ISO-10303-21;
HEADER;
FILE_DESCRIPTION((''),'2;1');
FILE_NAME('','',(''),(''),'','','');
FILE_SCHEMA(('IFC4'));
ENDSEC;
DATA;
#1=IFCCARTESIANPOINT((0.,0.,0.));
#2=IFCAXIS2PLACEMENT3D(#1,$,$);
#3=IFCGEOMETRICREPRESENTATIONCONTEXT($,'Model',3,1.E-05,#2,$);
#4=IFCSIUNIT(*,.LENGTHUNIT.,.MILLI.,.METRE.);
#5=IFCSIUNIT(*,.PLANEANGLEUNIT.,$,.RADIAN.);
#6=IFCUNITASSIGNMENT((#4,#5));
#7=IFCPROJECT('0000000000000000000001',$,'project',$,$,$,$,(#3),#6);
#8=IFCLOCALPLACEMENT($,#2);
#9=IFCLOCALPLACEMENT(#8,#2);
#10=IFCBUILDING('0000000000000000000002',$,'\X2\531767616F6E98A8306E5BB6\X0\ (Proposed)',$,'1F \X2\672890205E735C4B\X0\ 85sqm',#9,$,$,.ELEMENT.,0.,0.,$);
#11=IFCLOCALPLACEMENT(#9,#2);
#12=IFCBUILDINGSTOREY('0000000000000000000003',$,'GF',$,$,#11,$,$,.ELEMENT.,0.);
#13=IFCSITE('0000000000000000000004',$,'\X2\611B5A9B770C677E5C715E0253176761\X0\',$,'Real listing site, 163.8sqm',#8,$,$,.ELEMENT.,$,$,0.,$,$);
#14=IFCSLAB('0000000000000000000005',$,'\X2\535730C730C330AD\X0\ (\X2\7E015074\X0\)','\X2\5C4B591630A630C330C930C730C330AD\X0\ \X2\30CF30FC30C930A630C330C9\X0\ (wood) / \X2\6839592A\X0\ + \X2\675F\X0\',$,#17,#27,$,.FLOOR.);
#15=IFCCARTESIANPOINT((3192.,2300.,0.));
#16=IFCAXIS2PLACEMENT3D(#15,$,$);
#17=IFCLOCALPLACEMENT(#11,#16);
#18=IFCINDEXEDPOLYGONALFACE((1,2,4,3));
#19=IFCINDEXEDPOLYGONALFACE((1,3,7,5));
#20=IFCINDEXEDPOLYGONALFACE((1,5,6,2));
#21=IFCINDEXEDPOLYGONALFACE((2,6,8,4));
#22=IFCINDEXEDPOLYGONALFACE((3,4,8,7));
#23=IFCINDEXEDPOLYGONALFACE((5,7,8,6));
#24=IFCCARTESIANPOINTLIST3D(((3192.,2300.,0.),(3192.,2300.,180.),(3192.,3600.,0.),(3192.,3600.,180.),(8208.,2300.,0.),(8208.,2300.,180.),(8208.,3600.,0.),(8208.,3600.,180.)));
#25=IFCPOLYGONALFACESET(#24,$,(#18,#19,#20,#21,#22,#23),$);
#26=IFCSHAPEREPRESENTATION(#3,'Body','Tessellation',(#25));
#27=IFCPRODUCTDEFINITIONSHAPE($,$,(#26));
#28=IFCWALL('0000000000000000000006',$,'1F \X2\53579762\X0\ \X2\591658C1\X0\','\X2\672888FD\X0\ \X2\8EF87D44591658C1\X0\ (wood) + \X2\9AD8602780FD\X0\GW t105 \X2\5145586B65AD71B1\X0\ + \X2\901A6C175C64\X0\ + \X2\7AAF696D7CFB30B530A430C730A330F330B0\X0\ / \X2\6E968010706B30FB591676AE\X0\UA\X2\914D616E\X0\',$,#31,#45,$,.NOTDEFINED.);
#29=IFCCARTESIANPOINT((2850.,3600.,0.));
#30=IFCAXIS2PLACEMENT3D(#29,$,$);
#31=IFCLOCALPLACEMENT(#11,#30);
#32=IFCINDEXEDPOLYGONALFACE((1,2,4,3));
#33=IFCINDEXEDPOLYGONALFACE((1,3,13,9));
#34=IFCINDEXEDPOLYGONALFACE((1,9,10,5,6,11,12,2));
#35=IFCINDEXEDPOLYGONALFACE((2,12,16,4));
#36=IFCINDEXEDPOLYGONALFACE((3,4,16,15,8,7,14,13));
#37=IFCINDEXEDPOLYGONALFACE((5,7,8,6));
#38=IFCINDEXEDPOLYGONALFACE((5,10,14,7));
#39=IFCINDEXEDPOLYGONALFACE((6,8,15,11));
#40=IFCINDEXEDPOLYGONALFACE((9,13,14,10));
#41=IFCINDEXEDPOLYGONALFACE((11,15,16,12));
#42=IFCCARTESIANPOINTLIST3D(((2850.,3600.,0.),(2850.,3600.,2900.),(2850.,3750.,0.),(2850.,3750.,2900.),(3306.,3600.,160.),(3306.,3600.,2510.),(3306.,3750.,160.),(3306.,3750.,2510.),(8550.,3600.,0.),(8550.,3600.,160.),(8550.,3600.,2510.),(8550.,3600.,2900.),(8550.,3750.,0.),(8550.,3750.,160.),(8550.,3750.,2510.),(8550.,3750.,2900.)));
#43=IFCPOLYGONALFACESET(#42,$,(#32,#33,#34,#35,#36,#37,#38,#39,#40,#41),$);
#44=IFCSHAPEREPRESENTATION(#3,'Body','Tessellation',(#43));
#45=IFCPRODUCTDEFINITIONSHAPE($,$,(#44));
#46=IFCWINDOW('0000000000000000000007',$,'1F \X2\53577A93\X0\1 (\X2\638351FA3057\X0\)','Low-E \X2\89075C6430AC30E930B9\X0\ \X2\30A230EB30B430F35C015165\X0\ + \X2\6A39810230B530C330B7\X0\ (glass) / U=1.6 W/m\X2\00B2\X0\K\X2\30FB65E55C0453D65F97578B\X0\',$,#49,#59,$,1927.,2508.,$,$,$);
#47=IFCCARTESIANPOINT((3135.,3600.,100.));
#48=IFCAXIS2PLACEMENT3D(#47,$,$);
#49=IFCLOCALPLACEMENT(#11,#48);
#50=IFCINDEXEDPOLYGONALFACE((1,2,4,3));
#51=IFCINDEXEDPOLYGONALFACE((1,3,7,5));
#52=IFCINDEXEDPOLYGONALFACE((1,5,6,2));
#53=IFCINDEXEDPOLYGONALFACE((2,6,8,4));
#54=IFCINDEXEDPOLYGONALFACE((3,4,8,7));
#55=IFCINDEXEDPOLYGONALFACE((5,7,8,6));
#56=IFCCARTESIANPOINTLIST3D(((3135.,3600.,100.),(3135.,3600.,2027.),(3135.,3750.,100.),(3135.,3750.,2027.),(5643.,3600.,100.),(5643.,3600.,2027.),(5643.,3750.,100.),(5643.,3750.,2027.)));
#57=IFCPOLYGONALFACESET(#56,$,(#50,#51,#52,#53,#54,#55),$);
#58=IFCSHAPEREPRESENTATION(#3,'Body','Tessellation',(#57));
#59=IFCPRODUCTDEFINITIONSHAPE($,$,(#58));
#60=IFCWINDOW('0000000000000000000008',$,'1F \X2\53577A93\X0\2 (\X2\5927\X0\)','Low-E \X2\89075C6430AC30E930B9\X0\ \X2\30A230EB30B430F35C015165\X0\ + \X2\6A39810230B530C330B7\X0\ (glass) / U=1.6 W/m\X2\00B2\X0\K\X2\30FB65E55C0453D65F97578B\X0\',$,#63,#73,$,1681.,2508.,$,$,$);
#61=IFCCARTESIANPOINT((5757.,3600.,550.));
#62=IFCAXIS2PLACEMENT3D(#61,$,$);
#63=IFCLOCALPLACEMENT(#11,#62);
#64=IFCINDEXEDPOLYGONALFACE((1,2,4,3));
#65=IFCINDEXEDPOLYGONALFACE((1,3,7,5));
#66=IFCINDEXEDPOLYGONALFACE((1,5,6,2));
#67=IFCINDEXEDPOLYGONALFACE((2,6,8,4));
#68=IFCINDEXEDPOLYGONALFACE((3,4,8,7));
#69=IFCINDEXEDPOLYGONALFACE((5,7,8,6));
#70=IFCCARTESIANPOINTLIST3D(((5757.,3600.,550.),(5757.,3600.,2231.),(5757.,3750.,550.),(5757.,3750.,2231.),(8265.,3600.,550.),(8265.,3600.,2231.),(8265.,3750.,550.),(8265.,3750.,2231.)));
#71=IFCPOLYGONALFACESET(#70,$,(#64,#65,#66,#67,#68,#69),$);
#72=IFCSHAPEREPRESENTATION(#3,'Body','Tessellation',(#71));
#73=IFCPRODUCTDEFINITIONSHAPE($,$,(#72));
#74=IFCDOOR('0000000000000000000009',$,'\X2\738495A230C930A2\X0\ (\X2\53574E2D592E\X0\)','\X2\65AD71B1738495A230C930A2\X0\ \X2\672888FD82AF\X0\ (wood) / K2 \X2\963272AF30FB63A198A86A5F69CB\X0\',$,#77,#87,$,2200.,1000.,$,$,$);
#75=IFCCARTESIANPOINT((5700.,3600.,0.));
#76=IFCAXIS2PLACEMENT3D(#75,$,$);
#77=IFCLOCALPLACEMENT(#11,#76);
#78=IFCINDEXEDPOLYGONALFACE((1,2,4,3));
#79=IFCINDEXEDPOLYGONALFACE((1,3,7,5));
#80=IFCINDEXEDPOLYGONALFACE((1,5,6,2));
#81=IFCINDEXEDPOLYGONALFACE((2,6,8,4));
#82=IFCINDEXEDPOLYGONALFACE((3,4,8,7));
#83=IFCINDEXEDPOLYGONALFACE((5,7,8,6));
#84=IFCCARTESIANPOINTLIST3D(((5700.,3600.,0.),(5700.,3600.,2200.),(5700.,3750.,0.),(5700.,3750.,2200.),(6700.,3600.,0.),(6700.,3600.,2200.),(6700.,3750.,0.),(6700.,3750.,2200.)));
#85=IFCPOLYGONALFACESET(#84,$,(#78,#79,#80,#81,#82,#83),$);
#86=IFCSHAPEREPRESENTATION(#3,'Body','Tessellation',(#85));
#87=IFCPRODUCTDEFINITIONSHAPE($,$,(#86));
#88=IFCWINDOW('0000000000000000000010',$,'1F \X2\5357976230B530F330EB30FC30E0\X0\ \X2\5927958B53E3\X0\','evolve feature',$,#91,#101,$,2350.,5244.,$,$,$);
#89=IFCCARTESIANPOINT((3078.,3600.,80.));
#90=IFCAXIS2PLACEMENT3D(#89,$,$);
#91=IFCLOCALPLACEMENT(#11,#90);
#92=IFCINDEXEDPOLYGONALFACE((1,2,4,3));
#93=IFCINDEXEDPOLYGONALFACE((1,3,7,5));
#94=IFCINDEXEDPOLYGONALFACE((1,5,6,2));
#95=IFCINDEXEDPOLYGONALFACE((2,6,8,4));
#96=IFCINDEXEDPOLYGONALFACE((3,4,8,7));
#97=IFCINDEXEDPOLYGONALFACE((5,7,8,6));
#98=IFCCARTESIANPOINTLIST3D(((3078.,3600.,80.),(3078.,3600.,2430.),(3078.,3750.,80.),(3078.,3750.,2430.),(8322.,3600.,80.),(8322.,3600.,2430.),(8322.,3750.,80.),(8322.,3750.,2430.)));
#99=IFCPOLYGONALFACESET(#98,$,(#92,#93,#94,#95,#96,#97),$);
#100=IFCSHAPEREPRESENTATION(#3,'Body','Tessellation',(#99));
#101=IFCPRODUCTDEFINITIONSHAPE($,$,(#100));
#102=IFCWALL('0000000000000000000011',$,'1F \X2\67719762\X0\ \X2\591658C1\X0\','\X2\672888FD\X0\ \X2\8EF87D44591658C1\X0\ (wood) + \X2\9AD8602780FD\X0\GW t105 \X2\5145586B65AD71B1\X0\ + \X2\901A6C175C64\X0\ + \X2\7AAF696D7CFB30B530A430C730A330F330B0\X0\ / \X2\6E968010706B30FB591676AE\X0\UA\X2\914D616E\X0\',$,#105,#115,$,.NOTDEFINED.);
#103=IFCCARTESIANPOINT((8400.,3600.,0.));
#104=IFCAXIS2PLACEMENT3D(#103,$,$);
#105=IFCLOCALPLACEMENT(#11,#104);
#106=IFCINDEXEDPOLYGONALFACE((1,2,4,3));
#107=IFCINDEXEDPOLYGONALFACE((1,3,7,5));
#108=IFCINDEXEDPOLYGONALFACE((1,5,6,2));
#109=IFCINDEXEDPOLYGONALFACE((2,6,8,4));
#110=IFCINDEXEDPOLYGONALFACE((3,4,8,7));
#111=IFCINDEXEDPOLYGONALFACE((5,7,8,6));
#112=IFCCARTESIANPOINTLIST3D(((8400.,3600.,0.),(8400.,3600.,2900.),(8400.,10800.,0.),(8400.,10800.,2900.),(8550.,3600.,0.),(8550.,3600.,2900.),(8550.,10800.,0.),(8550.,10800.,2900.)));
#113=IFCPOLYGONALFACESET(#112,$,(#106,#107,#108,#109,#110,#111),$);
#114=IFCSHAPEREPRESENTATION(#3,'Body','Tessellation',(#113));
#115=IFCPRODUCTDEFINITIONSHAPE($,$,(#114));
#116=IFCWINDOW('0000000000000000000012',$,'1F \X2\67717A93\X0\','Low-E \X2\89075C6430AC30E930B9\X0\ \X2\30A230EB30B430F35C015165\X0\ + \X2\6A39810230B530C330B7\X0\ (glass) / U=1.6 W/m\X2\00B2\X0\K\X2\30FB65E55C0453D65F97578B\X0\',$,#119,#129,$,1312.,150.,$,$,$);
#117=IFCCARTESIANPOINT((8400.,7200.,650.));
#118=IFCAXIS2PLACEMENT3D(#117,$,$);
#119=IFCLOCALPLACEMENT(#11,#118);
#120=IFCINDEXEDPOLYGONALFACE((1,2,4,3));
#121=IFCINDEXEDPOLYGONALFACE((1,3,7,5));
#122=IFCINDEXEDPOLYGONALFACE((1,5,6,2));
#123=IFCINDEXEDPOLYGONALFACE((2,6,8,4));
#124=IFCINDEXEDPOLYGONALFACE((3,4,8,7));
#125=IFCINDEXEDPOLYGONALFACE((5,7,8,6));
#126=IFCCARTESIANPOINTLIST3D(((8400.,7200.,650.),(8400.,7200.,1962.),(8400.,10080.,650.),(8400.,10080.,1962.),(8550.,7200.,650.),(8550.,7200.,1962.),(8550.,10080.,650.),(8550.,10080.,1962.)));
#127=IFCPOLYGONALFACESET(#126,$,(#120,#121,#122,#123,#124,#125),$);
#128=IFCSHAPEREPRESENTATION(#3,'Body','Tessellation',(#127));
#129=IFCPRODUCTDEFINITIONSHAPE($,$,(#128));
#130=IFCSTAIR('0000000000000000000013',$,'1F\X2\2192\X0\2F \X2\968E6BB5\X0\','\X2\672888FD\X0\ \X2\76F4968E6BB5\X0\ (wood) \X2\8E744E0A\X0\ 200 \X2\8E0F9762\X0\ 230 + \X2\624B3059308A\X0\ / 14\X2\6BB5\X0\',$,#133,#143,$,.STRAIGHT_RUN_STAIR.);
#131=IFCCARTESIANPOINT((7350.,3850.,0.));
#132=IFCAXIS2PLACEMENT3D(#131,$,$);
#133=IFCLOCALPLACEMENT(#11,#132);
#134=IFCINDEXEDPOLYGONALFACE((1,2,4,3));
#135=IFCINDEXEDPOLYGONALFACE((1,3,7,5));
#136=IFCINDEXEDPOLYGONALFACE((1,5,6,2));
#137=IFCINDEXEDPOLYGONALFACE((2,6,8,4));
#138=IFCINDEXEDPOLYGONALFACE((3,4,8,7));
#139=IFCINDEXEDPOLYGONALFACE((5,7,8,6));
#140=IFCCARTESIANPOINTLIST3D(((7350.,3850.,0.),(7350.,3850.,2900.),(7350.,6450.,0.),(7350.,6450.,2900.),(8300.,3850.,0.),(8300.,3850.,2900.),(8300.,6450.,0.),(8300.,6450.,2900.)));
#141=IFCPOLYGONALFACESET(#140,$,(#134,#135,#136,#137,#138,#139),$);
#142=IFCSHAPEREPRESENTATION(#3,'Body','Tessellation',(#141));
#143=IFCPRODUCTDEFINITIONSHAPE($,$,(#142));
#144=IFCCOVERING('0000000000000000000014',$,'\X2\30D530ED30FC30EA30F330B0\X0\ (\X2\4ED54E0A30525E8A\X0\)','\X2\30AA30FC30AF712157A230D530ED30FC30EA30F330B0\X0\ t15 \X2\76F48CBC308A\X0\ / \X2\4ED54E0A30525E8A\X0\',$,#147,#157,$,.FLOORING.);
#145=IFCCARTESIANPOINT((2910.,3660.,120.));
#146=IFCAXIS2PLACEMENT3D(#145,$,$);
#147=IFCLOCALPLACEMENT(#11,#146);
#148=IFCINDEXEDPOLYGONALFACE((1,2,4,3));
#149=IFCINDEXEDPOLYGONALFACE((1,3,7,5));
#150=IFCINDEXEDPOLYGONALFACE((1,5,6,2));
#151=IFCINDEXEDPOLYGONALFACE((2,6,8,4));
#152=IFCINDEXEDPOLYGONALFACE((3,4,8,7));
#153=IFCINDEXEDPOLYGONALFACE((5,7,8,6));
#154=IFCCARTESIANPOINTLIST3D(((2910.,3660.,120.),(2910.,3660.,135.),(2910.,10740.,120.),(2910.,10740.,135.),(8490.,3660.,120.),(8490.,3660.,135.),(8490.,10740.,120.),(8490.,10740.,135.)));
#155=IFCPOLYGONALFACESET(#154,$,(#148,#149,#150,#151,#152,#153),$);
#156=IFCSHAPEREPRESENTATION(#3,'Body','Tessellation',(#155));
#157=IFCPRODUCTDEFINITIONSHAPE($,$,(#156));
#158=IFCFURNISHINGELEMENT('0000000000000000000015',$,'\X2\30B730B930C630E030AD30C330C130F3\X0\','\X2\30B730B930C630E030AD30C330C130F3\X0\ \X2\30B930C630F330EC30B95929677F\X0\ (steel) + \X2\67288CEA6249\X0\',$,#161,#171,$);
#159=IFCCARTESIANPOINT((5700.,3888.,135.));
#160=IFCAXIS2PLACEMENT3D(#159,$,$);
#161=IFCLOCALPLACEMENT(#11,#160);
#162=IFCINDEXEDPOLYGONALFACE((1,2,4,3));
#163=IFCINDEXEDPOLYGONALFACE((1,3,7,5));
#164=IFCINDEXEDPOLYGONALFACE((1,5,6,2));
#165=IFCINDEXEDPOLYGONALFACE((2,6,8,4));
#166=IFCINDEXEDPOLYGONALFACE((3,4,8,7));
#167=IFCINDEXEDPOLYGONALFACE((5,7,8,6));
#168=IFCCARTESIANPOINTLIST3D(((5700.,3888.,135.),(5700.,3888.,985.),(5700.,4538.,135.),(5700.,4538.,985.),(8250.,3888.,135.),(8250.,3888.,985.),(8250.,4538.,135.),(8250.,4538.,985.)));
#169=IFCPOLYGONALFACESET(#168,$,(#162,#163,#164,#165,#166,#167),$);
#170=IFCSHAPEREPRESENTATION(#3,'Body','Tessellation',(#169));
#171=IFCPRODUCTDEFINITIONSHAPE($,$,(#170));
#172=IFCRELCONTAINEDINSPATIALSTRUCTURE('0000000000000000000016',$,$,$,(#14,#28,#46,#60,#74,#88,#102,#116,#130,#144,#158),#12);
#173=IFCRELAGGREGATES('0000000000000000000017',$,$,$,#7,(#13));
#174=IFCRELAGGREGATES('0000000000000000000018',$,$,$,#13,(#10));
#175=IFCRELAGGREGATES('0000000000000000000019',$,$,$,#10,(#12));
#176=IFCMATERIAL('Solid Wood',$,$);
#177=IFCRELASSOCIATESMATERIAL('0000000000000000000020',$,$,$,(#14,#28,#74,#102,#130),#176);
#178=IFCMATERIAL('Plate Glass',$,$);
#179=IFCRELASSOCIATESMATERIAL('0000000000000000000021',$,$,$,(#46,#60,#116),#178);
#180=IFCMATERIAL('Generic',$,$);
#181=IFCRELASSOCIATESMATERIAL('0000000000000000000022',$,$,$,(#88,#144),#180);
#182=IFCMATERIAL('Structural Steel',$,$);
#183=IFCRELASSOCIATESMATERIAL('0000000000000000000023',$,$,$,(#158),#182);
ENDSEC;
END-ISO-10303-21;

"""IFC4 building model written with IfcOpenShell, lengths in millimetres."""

from ifc_helpers import new_model, si_unit, frame, frame_2d, origin, place, context, project, spatial, rectangle, extrude, material, element, fill, save


model = new_model("IFC4")

# Units and contexts
model_context = context("Model", 3, precision=1e-05, world=origin())
ifc_project = project(units=[si_unit("LENGTHUNIT", "METRE", prefix="MILLI"), si_unit("PLANEANGLEUNIT", "RADIAN")], contexts=[model_context])

# Site, building, storey
site_placement = place(None, origin())
site = spatial("IfcSite", under=ifc_project, at=site_placement, Name="愛媛県松山市北条", ObjectType="Real listing site, 163.8sqm", CompositionType="ELEMENT", RefElevation=0.0)
building_placement = place(site_placement, origin())
building = spatial("IfcBuilding", under=site, at=building_placement, Name="北条潮風の家 (Proposed)", ObjectType="1F 木造平屋 85sqm", CompositionType="ELEMENT", ElevationOfRefHeight=0.0, ElevationOfTerrain=0.0)
storey_placement = place(building_placement, origin())
storey = spatial("IfcBuildingStorey", under=building, at=storey_placement, Name="GF", CompositionType="ELEMENT", Elevation=0.0)

# Slab
ifc_material_1 = material(Name="Solid Wood")
slab_1_placement = place(storey_placement, frame((3192.0, 2300.0, 0.0)))
element("IfcSlab", 1, at=slab_1_placement, inside=storey, material=ifc_material_1, Name="南デッキ (縁側)", Description="屋外ウッドデッキ ハードウッド (wood) / 根太 + 束", PredefinedType="FLOOR", context=model_context, shape_type="SweptSolid", body=[
    extrude(rectangle(XDim=5016.0, YDim=1300.0, at=frame_2d((2508.0, 650.0))), frame((3192.0, 2300.0, 0.0)), (0.0, 0.0, 1.0), 180.0),
])
ifc_material_2 = material(Name="Generic")

# Wall, openings, windows, door
wall_1_placement = place(storey_placement, frame((2850.0, 3600.0, 0.0)))
wall_1 = element("IfcWall", 2, at=wall_1_placement, inside=storey, material=ifc_material_1, Name="1F 南面 外壁", Description="木製 軸組外壁 (wood) + 高性能GW t105 充填断熱 + 通気層 + 窯業系サイディング / 準耐火・外皮UA配慮", PredefinedType="NOTDEFINED", context=model_context, shape_type="SweptSolid", body=[
    extrude(rectangle(XDim=5700.0, YDim=150.0, at=frame_2d((2850.0, 75.0))), frame((2850.0, 3600.0, 0.0)), (0.0, 0.0, 1.0), 2900.0),
])
opening_1_placement = place(storey_placement, frame((3135.0, 3600.0, 100.0)))
opening_1 = element("IfcOpeningElement", 3, at=opening_1_placement, cuts=wall_1, PredefinedType="NOTDEFINED", context=model_context, shape_type="SweptSolid", body=[
    extrude(rectangle(XDim=2508.0, YDim=150.0, at=frame_2d((1254.0, 75.0))), frame((3135.0, 3600.0, 100.0)), (0.0, 0.0, 1.0), 1927.0),
])
opening_2_placement = place(storey_placement, frame((5757.0, 3600.0, 550.0)))
opening_2 = element("IfcOpeningElement", 4, at=opening_2_placement, cuts=wall_1, PredefinedType="NOTDEFINED", context=model_context, shape_type="SweptSolid", body=[
    extrude(rectangle(XDim=2508.0, YDim=150.0, at=frame_2d((1254.0, 75.0))), frame((5757.0, 3600.0, 550.0)), (0.0, 0.0, 1.0), 1681.0),
])
opening_3_placement = place(storey_placement, frame((5700.0, 3600.0, 0.0)))
opening_3 = element("IfcOpeningElement", 5, at=opening_3_placement, cuts=wall_1, PredefinedType="NOTDEFINED", context=model_context, shape_type="SweptSolid", body=[
    extrude(rectangle(XDim=1000.0, YDim=150.0, at=frame_2d((500.0, 75.0))), frame((5700.0, 3600.0, 0.0)), (0.0, 0.0, 1.0), 2200.0),
])
opening_4_placement = place(storey_placement, frame((3078.0, 3600.0, 80.0)))
opening_4 = element("IfcOpeningElement", 6, at=opening_4_placement, cuts=wall_1, PredefinedType="NOTDEFINED", context=model_context, shape_type="SweptSolid", body=[
    extrude(rectangle(XDim=5244.0, YDim=150.0, at=frame_2d((2622.0, 75.0))), frame((3078.0, 3600.0, 80.0)), (0.0, 0.0, 1.0), 2350.0),
])
ifc_material_3 = material(Name="Plate Glass")
window_1_placement = place(storey_placement, frame((3135.0, 3600.0, 100.0)))
window_1 = element("IfcWindow", 7, at=window_1_placement, inside=storey, material=ifc_material_3, Name="1F 南窓1 (掃出し)", Description="Low-E 複層ガラス アルゴン封入 + 樹脂サッシ (glass) / U=1.6 W/m²K・日射取得型", OverallHeight=1927.0, OverallWidth=2508.0, context=model_context, shape_type="SweptSolid", body=[
    extrude(rectangle(XDim=2508.0, YDim=150.0, at=frame_2d((1254.0, 75.0))), frame((3135.0, 3600.0, 100.0)), (0.0, 0.0, 1.0), 1927.0),
])
fill(opening_1, window_1)
window_2_placement = place(storey_placement, frame((5757.0, 3600.0, 550.0)))
window_2 = element("IfcWindow", 8, at=window_2_placement, inside=storey, material=ifc_material_3, Name="1F 南窓2 (大)", Description="Low-E 複層ガラス アルゴン封入 + 樹脂サッシ (glass) / U=1.6 W/m²K・日射取得型", OverallHeight=1681.0, OverallWidth=2508.0, context=model_context, shape_type="SweptSolid", body=[
    extrude(rectangle(XDim=2508.0, YDim=150.0, at=frame_2d((1254.0, 75.0))), frame((5757.0, 3600.0, 550.0)), (0.0, 0.0, 1.0), 1681.0),
])
fill(opening_2, window_2)
door_placement = place(storey_placement, frame((5700.0, 3600.0, 0.0)))
door = element("IfcDoor", 9, at=door_placement, inside=storey, material=ifc_material_1, Name="玄関ドア (南中央)", Description="断熱玄関ドア 木製芯 (wood) / K2 防犯・採風機構", OverallHeight=2200.0, OverallWidth=1000.0, context=model_context, shape_type="SweptSolid", body=[
    extrude(rectangle(XDim=1000.0, YDim=150.0, at=frame_2d((500.0, 75.0))), frame((5700.0, 3600.0, 0.0)), (0.0, 0.0, 1.0), 2200.0),
])
fill(opening_3, door)
window_3_placement = place(storey_placement, frame((3078.0, 3600.0, 80.0)))
window_3 = element("IfcWindow", 10, at=window_3_placement, inside=storey, material=ifc_material_2, Name="1F 南面サンルーム 大開口", Description="evolve feature", OverallHeight=2350.0, OverallWidth=5244.0, context=model_context, shape_type="SweptSolid", body=[
    extrude(rectangle(XDim=5244.0, YDim=150.0, at=frame_2d((2622.0, 75.0))), frame((3078.0, 3600.0, 80.0)), (0.0, 0.0, 1.0), 2350.0),
])
fill(opening_4, window_3)

# Wall, opening, window
wall_2_placement = place(storey_placement, frame((8400.0, 3600.0, 0.0)))
wall_2 = element("IfcWall", 11, at=wall_2_placement, inside=storey, material=ifc_material_1, Name="1F 東面 外壁", Description="木製 軸組外壁 (wood) + 高性能GW t105 充填断熱 + 通気層 + 窯業系サイディング / 準耐火・外皮UA配慮", PredefinedType="NOTDEFINED", context=model_context, shape_type="SweptSolid", body=[
    extrude(rectangle(XDim=150.0, YDim=7200.0, at=frame_2d((75.0, 3600.0))), frame((8400.0, 3600.0, 0.0)), (0.0, 0.0, 1.0), 2900.0),
])
opening_5_placement = place(storey_placement, frame((8400.0, 7200.0, 650.0)))
opening_5 = element("IfcOpeningElement", 12, at=opening_5_placement, cuts=wall_2, PredefinedType="NOTDEFINED", context=model_context, shape_type="SweptSolid", body=[
    extrude(rectangle(XDim=150.0, YDim=2880.0, at=frame_2d((75.0, 1440.0))), frame((8400.0, 7200.0, 650.0)), (0.0, 0.0, 1.0), 1312.0),
])
window_4_placement = place(storey_placement, frame((8400.0, 7200.0, 650.0)))
window_4 = element("IfcWindow", 13, at=window_4_placement, inside=storey, material=ifc_material_3, Name="1F 東窓", Description="Low-E 複層ガラス アルゴン封入 + 樹脂サッシ (glass) / U=1.6 W/m²K・日射取得型", OverallHeight=1312.0, OverallWidth=150.0, context=model_context, shape_type="SweptSolid", body=[
    extrude(rectangle(XDim=150.0, YDim=2880.0, at=frame_2d((75.0, 1440.0))), frame((8400.0, 7200.0, 650.0)), (0.0, 0.0, 1.0), 1312.0),
])
fill(opening_5, window_4)

# Stair
stair_placement = place(storey_placement, frame((7350.0, 3850.0, 0.0)))
element("IfcStair", 14, at=stair_placement, inside=storey, material=ifc_material_1, Name="1F→2F 階段", Description="木製 直階段 (wood) 蹴上 200 踏面 230 + 手すり / 14段", PredefinedType="STRAIGHT_RUN_STAIR", context=model_context, shape_type="SweptSolid", body=[
    extrude(rectangle(XDim=950.0, YDim=2600.0, at=frame_2d((475.0, 1300.0))), frame((7350.0, 3850.0, 0.0)), (0.0, 0.0, 1.0), 2900.0),
])

# Covering
covering_placement = place(storey_placement, frame((2910.0, 3660.0, 120.0)))
element("IfcCovering", 15, at=covering_placement, inside=storey, material=ifc_material_2, Name="フローリング (仕上げ床)", Description="オーク無垢フローリング t15 直貼り / 仕上げ床", PredefinedType="FLOORING", context=model_context, shape_type="SweptSolid", body=[
    extrude(rectangle(XDim=5580.0, YDim=7080.0, at=frame_2d((2790.0, 3540.0))), frame((2910.0, 3660.0, 120.0)), (0.0, 0.0, 1.0), 15.0),
])

# Furnishing element
ifc_material_4 = material(Name="Structural Steel")
furnishing_placement = place(storey_placement, frame((5700.0, 3888.0, 135.0)))
element("IfcFurnishingElement", 16, at=furnishing_placement, inside=storey, material=ifc_material_4, Name="システムキッチン", Description="システムキッチン ステンレス天板 (steel) + 木質扉", context=model_context, shape_type="SweptSolid", body=[
    extrude(rectangle(XDim=2550.0, YDim=650.0, at=frame_2d((1275.0, 325.0))), frame((5700.0, 3888.0, 135.0)), (0.0, 0.0, 1.0), 850.0),
])

save(model, "model.ifc")
